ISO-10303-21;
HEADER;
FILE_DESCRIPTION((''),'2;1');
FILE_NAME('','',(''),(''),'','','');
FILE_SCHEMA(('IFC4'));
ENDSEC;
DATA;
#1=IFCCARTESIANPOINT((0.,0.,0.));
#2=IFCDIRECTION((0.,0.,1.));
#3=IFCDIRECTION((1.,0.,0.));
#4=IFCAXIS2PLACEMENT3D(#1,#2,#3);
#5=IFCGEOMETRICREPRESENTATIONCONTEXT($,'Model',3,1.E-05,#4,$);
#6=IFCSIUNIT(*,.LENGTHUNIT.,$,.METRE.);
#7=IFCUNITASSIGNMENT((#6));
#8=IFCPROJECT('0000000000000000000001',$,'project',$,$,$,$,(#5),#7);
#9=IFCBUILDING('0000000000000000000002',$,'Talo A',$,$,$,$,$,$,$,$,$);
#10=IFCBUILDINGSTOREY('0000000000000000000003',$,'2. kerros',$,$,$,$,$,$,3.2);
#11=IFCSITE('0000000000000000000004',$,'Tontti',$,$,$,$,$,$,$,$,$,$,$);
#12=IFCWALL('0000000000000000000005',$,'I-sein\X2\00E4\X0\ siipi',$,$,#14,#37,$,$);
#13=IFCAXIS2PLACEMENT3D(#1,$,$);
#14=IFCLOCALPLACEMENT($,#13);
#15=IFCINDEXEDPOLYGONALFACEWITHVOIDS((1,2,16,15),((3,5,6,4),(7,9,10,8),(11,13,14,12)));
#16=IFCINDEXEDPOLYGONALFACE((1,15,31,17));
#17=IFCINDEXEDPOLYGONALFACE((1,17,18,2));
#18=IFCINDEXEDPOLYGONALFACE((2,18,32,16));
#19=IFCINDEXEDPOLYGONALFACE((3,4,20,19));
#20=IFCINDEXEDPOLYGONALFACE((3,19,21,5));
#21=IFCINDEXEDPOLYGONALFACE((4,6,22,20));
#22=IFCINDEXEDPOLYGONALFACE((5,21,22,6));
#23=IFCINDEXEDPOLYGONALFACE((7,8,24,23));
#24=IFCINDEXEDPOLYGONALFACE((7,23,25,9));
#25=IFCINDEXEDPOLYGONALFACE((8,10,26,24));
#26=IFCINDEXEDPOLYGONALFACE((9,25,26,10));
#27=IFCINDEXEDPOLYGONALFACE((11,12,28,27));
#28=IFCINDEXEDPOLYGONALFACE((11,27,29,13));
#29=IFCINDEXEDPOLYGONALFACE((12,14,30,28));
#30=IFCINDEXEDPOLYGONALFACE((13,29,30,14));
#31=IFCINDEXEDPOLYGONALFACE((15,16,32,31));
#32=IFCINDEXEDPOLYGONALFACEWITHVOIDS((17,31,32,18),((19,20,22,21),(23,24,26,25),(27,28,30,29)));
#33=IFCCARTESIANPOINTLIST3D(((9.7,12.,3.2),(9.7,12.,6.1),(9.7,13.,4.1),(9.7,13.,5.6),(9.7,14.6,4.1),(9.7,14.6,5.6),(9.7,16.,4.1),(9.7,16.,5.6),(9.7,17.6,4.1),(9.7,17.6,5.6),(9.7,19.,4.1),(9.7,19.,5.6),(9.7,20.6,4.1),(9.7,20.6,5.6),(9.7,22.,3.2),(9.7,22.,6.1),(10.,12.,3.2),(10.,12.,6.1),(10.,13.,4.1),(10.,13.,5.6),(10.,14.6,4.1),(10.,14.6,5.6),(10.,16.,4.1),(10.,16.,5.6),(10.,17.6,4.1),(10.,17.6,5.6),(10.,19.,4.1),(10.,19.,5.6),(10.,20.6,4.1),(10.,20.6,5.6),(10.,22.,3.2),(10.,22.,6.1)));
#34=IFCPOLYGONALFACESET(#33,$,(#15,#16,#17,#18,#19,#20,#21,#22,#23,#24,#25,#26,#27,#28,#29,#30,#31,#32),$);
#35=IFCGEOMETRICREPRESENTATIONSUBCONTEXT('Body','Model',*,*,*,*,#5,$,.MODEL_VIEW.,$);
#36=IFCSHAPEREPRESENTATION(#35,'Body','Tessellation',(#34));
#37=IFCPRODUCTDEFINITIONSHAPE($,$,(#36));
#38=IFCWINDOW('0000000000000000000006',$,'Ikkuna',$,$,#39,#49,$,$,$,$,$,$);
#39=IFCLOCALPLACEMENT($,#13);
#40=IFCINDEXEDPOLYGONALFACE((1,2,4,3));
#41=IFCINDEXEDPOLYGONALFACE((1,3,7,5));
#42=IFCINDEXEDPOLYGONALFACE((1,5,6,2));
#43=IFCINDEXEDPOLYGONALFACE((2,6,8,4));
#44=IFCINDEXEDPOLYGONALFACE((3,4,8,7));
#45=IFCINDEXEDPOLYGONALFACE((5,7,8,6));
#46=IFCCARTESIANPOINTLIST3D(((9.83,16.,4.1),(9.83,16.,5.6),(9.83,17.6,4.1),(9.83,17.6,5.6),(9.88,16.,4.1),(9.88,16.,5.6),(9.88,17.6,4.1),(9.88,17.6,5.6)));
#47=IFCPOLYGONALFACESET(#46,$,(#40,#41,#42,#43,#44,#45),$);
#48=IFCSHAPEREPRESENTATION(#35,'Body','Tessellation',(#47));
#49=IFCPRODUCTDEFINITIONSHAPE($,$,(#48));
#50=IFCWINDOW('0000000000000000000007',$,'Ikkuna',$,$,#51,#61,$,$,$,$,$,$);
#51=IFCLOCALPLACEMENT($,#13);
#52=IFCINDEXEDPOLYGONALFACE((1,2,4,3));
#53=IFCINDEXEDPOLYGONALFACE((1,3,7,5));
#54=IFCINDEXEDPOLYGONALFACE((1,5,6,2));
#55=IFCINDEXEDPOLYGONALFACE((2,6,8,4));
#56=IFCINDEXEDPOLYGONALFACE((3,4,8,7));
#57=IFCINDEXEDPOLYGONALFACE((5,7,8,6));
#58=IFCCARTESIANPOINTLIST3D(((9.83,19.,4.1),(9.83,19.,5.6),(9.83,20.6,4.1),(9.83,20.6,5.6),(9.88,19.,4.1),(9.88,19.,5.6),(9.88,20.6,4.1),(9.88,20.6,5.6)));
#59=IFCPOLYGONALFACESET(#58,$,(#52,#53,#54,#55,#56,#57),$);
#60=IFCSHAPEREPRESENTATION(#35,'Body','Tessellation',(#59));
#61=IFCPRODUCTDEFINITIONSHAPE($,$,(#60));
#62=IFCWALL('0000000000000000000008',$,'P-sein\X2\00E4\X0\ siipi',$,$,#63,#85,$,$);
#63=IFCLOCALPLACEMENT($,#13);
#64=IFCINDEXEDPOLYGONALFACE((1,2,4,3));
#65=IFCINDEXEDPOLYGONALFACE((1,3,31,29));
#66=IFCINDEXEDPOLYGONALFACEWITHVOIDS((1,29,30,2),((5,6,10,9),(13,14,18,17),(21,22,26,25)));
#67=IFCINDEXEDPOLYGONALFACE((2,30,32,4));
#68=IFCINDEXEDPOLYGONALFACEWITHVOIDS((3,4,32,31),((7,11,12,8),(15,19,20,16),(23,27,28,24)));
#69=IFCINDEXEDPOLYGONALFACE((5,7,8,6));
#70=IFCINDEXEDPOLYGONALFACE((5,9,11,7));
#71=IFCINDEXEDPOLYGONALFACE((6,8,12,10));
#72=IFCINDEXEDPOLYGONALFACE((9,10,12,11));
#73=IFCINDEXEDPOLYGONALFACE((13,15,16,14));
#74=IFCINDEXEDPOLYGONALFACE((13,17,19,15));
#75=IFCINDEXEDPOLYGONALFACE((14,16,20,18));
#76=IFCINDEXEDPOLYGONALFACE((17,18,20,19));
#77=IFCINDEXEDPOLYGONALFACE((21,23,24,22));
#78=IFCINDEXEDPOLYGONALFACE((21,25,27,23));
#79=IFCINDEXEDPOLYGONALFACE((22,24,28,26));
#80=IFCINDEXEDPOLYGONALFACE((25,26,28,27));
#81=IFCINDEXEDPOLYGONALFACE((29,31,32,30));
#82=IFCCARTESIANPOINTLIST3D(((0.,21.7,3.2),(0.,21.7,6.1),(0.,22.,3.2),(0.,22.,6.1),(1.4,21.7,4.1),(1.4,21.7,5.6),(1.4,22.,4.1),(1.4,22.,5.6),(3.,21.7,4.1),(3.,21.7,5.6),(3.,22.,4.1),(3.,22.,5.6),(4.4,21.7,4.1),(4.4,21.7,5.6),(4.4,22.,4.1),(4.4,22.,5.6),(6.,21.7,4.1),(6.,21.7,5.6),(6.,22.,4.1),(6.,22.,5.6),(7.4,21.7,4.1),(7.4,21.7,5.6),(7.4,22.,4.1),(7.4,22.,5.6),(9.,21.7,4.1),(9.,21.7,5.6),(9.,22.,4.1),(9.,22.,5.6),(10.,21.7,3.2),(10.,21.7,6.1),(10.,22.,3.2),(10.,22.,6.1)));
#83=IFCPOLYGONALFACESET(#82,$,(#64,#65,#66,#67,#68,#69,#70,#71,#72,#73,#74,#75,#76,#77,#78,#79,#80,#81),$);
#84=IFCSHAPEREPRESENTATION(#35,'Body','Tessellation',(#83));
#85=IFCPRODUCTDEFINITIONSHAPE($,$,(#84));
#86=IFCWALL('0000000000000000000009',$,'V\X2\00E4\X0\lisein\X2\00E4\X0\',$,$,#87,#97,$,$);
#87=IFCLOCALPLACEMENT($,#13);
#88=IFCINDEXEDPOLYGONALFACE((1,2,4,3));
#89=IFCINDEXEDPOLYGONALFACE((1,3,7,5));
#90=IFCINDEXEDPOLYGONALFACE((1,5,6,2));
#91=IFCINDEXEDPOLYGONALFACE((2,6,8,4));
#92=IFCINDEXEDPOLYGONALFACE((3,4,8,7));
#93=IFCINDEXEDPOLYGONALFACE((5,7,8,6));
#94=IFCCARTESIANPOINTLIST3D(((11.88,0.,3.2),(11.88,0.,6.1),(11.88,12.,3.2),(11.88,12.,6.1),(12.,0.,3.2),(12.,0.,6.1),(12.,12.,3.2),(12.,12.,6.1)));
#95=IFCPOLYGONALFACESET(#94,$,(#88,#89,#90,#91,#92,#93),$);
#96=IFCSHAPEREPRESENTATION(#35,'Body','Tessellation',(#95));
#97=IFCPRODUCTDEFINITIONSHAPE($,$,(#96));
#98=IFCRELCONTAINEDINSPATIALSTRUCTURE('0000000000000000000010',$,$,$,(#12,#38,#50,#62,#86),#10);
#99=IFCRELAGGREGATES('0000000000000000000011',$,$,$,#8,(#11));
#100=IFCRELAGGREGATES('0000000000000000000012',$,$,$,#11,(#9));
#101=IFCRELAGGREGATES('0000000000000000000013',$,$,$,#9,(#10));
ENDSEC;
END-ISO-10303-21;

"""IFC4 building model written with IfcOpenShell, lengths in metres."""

from ifc_helpers import new_model, si_unit, frame, origin_with_axes, place, context, subcontext, project, spatial, indexed_curve, outline, extrude, element, save


model = new_model("IFC4")

# Units and contexts
model_context = context("Model", 3, precision=1e-05, world=origin_with_axes())
body_context = subcontext(model_context, "Body", "Model", "MODEL_VIEW")
ifc_project = project(units=[si_unit("LENGTHUNIT", "METRE")], contexts=[model_context])

# Site, building, storey
site = spatial("IfcSite", under=ifc_project, Name="Tontti")
building = spatial("IfcBuilding", under=site, Name="Talo A")
storey = spatial("IfcBuildingStorey", under=building, Name="2. kerros", Elevation=3.2)

# Wall, openings
wall_1_placement = place(None, frame((10.0, 12.0, 3.2), z_axis=(0.0, 0.0, 1.0), x_axis=(0.0, 1.0, 0.0)))
wall_1 = element("IfcWall", 1, at=wall_1_placement, inside=storey, Name="I-seinä siipi", context=body_context, shape_type="SweptSolid", body=[
    extrude(outline(indexed_curve([(0.0, 0.0), (0.0, 0.3), (10.0, 0.3), (10.0, 0.0), (0.0, 0.0)], self_intersect=False)), origin_with_axes(), (0.0, 0.0, 1.0), 2.9),
])
opening_1_placement = place(wall_1_placement, frame((1.0, -0.1, 0.9), z_axis=(0.0, 0.0, 1.0), x_axis=(1.0, 0.0, 0.0)))
element("IfcOpeningElement", 2, at=opening_1_placement, cuts=wall_1, context=body_context, shape_type="SweptSolid", body=[
    extrude(outline(indexed_curve([(0.0, 0.0), (0.0, 0.5), (1.6, 0.5), (1.6, 0.0), (0.0, 0.0)], self_intersect=False)), origin_with_axes(), (0.0, 0.0, 1.0), 1.5),
])
opening_2_placement = place(wall_1_placement, frame((4.0, -0.1, 0.9), z_axis=(0.0, 0.0, 1.0), x_axis=(1.0, 0.0, 0.0)))
element("IfcOpeningElement", 3, at=opening_2_placement, cuts=wall_1, context=body_context, shape_type="SweptSolid", body=[
    extrude(outline(indexed_curve([(0.0, 0.0), (0.0, 0.5), (1.6, 0.5), (1.6, 0.0), (0.0, 0.0)], self_intersect=False)), origin_with_axes(), (0.0, 0.0, 1.0), 1.5),
])
opening_3_placement = place(wall_1_placement, frame((7.0, -0.1, 0.9), z_axis=(0.0, 0.0, 1.0), x_axis=(1.0, 0.0, 0.0)))
element("IfcOpeningElement", 4, at=opening_3_placement, cuts=wall_1, context=body_context, shape_type="SweptSolid", body=[
    extrude(outline(indexed_curve([(0.0, 0.0), (0.0, 0.5), (1.6, 0.5), (1.6, 0.0), (0.0, 0.0)], self_intersect=False)), origin_with_axes(), (0.0, 0.0, 1.0), 1.5),
])

# Windows
for number, where, z_axis, x_axis, name in (
    (5, (9.88, 16.0, 4.1), (0.0, 0.0, 1.0), (0.0, 1.0, 0.0), "Ikkuna"),
    (6, (9.88, 19.0, 4.1), (0.0, 0.0, 1.0), (0.0, 1.0, 0.0), "Ikkuna"),
):
    element("IfcWindow", number, at=place(None, frame(where, z_axis=z_axis, x_axis=x_axis)), inside=storey, Name=name, context=body_context, shape_type="SweptSolid", body=[
        extrude(outline(indexed_curve([(0.0, 0.0), (0.0, 0.05), (1.6, 0.05), (1.6, 0.0), (0.0, 0.0)], self_intersect=False)), origin_with_axes(), (0.0, 0.0, 1.0), 1.5),
    ])

# Wall, openings
wall_2_placement = place(None, frame((10.0, 22.0, 3.2), z_axis=(0.0, 0.0, 1.0), x_axis=(-1.0, 0.0, 0.0)))
wall_2 = element("IfcWall", 7, at=wall_2_placement, inside=storey, Name="P-seinä siipi", context=body_context, shape_type="SweptSolid", body=[
    extrude(outline(indexed_curve([(0.0, 0.0), (0.0, 0.3), (10.0, 0.3), (10.0, 0.0), (0.0, 0.0)], self_intersect=False)), origin_with_axes(), (0.0, 0.0, 1.0), 2.9),
])
opening_4_placement = place(wall_2_placement, frame((1.0, -0.1, 0.9), z_axis=(0.0, 0.0, 1.0), x_axis=(1.0, 0.0, 0.0)))
element("IfcOpeningElement", 8, at=opening_4_placement, cuts=wall_2, context=body_context, shape_type="SweptSolid", body=[
    extrude(outline(indexed_curve([(0.0, 0.0), (0.0, 0.5), (1.6, 0.5), (1.6, 0.0), (0.0, 0.0)], self_intersect=False)), origin_with_axes(), (0.0, 0.0, 1.0), 1.5),
])
opening_5_placement = place(wall_2_placement, frame((4.0, -0.1, 0.9), z_axis=(0.0, 0.0, 1.0), x_axis=(1.0, 0.0, 0.0)))
element("IfcOpeningElement", 9, at=opening_5_placement, cuts=wall_2, context=body_context, shape_type="SweptSolid", body=[
    extrude(outline(indexed_curve([(0.0, 0.0), (0.0, 0.5), (1.6, 0.5), (1.6, 0.0), (0.0, 0.0)], self_intersect=False)), origin_with_axes(), (0.0, 0.0, 1.0), 1.5),
])
opening_6_placement = place(wall_2_placement, frame((7.0, -0.1, 0.9), z_axis=(0.0, 0.0, 1.0), x_axis=(1.0, 0.0, 0.0)))
element("IfcOpeningElement", 10, at=opening_6_placement, cuts=wall_2, context=body_context, shape_type="SweptSolid", body=[
    extrude(outline(indexed_curve([(0.0, 0.0), (0.0, 0.5), (1.6, 0.5), (1.6, 0.0), (0.0, 0.0)], self_intersect=False)), origin_with_axes(), (0.0, 0.0, 1.0), 1.5),
])

# Wall
wall_3_placement = place(None, frame((12.0, 0.0, 3.2), z_axis=(0.0, 0.0, 1.0), x_axis=(0.0, 1.0, 0.0)))
element("IfcWall", 11, at=wall_3_placement, inside=storey, Name="Väliseinä", context=body_context, shape_type="SweptSolid", body=[
    extrude(outline(indexed_curve([(0.0, 0.0), (0.0, 0.12), (12.0, 0.12), (12.0, 0.0), (0.0, 0.0)], self_intersect=False)), origin_with_axes(), (0.0, 0.0, 1.0), 2.9),
])

save(model, "model.ifc")
